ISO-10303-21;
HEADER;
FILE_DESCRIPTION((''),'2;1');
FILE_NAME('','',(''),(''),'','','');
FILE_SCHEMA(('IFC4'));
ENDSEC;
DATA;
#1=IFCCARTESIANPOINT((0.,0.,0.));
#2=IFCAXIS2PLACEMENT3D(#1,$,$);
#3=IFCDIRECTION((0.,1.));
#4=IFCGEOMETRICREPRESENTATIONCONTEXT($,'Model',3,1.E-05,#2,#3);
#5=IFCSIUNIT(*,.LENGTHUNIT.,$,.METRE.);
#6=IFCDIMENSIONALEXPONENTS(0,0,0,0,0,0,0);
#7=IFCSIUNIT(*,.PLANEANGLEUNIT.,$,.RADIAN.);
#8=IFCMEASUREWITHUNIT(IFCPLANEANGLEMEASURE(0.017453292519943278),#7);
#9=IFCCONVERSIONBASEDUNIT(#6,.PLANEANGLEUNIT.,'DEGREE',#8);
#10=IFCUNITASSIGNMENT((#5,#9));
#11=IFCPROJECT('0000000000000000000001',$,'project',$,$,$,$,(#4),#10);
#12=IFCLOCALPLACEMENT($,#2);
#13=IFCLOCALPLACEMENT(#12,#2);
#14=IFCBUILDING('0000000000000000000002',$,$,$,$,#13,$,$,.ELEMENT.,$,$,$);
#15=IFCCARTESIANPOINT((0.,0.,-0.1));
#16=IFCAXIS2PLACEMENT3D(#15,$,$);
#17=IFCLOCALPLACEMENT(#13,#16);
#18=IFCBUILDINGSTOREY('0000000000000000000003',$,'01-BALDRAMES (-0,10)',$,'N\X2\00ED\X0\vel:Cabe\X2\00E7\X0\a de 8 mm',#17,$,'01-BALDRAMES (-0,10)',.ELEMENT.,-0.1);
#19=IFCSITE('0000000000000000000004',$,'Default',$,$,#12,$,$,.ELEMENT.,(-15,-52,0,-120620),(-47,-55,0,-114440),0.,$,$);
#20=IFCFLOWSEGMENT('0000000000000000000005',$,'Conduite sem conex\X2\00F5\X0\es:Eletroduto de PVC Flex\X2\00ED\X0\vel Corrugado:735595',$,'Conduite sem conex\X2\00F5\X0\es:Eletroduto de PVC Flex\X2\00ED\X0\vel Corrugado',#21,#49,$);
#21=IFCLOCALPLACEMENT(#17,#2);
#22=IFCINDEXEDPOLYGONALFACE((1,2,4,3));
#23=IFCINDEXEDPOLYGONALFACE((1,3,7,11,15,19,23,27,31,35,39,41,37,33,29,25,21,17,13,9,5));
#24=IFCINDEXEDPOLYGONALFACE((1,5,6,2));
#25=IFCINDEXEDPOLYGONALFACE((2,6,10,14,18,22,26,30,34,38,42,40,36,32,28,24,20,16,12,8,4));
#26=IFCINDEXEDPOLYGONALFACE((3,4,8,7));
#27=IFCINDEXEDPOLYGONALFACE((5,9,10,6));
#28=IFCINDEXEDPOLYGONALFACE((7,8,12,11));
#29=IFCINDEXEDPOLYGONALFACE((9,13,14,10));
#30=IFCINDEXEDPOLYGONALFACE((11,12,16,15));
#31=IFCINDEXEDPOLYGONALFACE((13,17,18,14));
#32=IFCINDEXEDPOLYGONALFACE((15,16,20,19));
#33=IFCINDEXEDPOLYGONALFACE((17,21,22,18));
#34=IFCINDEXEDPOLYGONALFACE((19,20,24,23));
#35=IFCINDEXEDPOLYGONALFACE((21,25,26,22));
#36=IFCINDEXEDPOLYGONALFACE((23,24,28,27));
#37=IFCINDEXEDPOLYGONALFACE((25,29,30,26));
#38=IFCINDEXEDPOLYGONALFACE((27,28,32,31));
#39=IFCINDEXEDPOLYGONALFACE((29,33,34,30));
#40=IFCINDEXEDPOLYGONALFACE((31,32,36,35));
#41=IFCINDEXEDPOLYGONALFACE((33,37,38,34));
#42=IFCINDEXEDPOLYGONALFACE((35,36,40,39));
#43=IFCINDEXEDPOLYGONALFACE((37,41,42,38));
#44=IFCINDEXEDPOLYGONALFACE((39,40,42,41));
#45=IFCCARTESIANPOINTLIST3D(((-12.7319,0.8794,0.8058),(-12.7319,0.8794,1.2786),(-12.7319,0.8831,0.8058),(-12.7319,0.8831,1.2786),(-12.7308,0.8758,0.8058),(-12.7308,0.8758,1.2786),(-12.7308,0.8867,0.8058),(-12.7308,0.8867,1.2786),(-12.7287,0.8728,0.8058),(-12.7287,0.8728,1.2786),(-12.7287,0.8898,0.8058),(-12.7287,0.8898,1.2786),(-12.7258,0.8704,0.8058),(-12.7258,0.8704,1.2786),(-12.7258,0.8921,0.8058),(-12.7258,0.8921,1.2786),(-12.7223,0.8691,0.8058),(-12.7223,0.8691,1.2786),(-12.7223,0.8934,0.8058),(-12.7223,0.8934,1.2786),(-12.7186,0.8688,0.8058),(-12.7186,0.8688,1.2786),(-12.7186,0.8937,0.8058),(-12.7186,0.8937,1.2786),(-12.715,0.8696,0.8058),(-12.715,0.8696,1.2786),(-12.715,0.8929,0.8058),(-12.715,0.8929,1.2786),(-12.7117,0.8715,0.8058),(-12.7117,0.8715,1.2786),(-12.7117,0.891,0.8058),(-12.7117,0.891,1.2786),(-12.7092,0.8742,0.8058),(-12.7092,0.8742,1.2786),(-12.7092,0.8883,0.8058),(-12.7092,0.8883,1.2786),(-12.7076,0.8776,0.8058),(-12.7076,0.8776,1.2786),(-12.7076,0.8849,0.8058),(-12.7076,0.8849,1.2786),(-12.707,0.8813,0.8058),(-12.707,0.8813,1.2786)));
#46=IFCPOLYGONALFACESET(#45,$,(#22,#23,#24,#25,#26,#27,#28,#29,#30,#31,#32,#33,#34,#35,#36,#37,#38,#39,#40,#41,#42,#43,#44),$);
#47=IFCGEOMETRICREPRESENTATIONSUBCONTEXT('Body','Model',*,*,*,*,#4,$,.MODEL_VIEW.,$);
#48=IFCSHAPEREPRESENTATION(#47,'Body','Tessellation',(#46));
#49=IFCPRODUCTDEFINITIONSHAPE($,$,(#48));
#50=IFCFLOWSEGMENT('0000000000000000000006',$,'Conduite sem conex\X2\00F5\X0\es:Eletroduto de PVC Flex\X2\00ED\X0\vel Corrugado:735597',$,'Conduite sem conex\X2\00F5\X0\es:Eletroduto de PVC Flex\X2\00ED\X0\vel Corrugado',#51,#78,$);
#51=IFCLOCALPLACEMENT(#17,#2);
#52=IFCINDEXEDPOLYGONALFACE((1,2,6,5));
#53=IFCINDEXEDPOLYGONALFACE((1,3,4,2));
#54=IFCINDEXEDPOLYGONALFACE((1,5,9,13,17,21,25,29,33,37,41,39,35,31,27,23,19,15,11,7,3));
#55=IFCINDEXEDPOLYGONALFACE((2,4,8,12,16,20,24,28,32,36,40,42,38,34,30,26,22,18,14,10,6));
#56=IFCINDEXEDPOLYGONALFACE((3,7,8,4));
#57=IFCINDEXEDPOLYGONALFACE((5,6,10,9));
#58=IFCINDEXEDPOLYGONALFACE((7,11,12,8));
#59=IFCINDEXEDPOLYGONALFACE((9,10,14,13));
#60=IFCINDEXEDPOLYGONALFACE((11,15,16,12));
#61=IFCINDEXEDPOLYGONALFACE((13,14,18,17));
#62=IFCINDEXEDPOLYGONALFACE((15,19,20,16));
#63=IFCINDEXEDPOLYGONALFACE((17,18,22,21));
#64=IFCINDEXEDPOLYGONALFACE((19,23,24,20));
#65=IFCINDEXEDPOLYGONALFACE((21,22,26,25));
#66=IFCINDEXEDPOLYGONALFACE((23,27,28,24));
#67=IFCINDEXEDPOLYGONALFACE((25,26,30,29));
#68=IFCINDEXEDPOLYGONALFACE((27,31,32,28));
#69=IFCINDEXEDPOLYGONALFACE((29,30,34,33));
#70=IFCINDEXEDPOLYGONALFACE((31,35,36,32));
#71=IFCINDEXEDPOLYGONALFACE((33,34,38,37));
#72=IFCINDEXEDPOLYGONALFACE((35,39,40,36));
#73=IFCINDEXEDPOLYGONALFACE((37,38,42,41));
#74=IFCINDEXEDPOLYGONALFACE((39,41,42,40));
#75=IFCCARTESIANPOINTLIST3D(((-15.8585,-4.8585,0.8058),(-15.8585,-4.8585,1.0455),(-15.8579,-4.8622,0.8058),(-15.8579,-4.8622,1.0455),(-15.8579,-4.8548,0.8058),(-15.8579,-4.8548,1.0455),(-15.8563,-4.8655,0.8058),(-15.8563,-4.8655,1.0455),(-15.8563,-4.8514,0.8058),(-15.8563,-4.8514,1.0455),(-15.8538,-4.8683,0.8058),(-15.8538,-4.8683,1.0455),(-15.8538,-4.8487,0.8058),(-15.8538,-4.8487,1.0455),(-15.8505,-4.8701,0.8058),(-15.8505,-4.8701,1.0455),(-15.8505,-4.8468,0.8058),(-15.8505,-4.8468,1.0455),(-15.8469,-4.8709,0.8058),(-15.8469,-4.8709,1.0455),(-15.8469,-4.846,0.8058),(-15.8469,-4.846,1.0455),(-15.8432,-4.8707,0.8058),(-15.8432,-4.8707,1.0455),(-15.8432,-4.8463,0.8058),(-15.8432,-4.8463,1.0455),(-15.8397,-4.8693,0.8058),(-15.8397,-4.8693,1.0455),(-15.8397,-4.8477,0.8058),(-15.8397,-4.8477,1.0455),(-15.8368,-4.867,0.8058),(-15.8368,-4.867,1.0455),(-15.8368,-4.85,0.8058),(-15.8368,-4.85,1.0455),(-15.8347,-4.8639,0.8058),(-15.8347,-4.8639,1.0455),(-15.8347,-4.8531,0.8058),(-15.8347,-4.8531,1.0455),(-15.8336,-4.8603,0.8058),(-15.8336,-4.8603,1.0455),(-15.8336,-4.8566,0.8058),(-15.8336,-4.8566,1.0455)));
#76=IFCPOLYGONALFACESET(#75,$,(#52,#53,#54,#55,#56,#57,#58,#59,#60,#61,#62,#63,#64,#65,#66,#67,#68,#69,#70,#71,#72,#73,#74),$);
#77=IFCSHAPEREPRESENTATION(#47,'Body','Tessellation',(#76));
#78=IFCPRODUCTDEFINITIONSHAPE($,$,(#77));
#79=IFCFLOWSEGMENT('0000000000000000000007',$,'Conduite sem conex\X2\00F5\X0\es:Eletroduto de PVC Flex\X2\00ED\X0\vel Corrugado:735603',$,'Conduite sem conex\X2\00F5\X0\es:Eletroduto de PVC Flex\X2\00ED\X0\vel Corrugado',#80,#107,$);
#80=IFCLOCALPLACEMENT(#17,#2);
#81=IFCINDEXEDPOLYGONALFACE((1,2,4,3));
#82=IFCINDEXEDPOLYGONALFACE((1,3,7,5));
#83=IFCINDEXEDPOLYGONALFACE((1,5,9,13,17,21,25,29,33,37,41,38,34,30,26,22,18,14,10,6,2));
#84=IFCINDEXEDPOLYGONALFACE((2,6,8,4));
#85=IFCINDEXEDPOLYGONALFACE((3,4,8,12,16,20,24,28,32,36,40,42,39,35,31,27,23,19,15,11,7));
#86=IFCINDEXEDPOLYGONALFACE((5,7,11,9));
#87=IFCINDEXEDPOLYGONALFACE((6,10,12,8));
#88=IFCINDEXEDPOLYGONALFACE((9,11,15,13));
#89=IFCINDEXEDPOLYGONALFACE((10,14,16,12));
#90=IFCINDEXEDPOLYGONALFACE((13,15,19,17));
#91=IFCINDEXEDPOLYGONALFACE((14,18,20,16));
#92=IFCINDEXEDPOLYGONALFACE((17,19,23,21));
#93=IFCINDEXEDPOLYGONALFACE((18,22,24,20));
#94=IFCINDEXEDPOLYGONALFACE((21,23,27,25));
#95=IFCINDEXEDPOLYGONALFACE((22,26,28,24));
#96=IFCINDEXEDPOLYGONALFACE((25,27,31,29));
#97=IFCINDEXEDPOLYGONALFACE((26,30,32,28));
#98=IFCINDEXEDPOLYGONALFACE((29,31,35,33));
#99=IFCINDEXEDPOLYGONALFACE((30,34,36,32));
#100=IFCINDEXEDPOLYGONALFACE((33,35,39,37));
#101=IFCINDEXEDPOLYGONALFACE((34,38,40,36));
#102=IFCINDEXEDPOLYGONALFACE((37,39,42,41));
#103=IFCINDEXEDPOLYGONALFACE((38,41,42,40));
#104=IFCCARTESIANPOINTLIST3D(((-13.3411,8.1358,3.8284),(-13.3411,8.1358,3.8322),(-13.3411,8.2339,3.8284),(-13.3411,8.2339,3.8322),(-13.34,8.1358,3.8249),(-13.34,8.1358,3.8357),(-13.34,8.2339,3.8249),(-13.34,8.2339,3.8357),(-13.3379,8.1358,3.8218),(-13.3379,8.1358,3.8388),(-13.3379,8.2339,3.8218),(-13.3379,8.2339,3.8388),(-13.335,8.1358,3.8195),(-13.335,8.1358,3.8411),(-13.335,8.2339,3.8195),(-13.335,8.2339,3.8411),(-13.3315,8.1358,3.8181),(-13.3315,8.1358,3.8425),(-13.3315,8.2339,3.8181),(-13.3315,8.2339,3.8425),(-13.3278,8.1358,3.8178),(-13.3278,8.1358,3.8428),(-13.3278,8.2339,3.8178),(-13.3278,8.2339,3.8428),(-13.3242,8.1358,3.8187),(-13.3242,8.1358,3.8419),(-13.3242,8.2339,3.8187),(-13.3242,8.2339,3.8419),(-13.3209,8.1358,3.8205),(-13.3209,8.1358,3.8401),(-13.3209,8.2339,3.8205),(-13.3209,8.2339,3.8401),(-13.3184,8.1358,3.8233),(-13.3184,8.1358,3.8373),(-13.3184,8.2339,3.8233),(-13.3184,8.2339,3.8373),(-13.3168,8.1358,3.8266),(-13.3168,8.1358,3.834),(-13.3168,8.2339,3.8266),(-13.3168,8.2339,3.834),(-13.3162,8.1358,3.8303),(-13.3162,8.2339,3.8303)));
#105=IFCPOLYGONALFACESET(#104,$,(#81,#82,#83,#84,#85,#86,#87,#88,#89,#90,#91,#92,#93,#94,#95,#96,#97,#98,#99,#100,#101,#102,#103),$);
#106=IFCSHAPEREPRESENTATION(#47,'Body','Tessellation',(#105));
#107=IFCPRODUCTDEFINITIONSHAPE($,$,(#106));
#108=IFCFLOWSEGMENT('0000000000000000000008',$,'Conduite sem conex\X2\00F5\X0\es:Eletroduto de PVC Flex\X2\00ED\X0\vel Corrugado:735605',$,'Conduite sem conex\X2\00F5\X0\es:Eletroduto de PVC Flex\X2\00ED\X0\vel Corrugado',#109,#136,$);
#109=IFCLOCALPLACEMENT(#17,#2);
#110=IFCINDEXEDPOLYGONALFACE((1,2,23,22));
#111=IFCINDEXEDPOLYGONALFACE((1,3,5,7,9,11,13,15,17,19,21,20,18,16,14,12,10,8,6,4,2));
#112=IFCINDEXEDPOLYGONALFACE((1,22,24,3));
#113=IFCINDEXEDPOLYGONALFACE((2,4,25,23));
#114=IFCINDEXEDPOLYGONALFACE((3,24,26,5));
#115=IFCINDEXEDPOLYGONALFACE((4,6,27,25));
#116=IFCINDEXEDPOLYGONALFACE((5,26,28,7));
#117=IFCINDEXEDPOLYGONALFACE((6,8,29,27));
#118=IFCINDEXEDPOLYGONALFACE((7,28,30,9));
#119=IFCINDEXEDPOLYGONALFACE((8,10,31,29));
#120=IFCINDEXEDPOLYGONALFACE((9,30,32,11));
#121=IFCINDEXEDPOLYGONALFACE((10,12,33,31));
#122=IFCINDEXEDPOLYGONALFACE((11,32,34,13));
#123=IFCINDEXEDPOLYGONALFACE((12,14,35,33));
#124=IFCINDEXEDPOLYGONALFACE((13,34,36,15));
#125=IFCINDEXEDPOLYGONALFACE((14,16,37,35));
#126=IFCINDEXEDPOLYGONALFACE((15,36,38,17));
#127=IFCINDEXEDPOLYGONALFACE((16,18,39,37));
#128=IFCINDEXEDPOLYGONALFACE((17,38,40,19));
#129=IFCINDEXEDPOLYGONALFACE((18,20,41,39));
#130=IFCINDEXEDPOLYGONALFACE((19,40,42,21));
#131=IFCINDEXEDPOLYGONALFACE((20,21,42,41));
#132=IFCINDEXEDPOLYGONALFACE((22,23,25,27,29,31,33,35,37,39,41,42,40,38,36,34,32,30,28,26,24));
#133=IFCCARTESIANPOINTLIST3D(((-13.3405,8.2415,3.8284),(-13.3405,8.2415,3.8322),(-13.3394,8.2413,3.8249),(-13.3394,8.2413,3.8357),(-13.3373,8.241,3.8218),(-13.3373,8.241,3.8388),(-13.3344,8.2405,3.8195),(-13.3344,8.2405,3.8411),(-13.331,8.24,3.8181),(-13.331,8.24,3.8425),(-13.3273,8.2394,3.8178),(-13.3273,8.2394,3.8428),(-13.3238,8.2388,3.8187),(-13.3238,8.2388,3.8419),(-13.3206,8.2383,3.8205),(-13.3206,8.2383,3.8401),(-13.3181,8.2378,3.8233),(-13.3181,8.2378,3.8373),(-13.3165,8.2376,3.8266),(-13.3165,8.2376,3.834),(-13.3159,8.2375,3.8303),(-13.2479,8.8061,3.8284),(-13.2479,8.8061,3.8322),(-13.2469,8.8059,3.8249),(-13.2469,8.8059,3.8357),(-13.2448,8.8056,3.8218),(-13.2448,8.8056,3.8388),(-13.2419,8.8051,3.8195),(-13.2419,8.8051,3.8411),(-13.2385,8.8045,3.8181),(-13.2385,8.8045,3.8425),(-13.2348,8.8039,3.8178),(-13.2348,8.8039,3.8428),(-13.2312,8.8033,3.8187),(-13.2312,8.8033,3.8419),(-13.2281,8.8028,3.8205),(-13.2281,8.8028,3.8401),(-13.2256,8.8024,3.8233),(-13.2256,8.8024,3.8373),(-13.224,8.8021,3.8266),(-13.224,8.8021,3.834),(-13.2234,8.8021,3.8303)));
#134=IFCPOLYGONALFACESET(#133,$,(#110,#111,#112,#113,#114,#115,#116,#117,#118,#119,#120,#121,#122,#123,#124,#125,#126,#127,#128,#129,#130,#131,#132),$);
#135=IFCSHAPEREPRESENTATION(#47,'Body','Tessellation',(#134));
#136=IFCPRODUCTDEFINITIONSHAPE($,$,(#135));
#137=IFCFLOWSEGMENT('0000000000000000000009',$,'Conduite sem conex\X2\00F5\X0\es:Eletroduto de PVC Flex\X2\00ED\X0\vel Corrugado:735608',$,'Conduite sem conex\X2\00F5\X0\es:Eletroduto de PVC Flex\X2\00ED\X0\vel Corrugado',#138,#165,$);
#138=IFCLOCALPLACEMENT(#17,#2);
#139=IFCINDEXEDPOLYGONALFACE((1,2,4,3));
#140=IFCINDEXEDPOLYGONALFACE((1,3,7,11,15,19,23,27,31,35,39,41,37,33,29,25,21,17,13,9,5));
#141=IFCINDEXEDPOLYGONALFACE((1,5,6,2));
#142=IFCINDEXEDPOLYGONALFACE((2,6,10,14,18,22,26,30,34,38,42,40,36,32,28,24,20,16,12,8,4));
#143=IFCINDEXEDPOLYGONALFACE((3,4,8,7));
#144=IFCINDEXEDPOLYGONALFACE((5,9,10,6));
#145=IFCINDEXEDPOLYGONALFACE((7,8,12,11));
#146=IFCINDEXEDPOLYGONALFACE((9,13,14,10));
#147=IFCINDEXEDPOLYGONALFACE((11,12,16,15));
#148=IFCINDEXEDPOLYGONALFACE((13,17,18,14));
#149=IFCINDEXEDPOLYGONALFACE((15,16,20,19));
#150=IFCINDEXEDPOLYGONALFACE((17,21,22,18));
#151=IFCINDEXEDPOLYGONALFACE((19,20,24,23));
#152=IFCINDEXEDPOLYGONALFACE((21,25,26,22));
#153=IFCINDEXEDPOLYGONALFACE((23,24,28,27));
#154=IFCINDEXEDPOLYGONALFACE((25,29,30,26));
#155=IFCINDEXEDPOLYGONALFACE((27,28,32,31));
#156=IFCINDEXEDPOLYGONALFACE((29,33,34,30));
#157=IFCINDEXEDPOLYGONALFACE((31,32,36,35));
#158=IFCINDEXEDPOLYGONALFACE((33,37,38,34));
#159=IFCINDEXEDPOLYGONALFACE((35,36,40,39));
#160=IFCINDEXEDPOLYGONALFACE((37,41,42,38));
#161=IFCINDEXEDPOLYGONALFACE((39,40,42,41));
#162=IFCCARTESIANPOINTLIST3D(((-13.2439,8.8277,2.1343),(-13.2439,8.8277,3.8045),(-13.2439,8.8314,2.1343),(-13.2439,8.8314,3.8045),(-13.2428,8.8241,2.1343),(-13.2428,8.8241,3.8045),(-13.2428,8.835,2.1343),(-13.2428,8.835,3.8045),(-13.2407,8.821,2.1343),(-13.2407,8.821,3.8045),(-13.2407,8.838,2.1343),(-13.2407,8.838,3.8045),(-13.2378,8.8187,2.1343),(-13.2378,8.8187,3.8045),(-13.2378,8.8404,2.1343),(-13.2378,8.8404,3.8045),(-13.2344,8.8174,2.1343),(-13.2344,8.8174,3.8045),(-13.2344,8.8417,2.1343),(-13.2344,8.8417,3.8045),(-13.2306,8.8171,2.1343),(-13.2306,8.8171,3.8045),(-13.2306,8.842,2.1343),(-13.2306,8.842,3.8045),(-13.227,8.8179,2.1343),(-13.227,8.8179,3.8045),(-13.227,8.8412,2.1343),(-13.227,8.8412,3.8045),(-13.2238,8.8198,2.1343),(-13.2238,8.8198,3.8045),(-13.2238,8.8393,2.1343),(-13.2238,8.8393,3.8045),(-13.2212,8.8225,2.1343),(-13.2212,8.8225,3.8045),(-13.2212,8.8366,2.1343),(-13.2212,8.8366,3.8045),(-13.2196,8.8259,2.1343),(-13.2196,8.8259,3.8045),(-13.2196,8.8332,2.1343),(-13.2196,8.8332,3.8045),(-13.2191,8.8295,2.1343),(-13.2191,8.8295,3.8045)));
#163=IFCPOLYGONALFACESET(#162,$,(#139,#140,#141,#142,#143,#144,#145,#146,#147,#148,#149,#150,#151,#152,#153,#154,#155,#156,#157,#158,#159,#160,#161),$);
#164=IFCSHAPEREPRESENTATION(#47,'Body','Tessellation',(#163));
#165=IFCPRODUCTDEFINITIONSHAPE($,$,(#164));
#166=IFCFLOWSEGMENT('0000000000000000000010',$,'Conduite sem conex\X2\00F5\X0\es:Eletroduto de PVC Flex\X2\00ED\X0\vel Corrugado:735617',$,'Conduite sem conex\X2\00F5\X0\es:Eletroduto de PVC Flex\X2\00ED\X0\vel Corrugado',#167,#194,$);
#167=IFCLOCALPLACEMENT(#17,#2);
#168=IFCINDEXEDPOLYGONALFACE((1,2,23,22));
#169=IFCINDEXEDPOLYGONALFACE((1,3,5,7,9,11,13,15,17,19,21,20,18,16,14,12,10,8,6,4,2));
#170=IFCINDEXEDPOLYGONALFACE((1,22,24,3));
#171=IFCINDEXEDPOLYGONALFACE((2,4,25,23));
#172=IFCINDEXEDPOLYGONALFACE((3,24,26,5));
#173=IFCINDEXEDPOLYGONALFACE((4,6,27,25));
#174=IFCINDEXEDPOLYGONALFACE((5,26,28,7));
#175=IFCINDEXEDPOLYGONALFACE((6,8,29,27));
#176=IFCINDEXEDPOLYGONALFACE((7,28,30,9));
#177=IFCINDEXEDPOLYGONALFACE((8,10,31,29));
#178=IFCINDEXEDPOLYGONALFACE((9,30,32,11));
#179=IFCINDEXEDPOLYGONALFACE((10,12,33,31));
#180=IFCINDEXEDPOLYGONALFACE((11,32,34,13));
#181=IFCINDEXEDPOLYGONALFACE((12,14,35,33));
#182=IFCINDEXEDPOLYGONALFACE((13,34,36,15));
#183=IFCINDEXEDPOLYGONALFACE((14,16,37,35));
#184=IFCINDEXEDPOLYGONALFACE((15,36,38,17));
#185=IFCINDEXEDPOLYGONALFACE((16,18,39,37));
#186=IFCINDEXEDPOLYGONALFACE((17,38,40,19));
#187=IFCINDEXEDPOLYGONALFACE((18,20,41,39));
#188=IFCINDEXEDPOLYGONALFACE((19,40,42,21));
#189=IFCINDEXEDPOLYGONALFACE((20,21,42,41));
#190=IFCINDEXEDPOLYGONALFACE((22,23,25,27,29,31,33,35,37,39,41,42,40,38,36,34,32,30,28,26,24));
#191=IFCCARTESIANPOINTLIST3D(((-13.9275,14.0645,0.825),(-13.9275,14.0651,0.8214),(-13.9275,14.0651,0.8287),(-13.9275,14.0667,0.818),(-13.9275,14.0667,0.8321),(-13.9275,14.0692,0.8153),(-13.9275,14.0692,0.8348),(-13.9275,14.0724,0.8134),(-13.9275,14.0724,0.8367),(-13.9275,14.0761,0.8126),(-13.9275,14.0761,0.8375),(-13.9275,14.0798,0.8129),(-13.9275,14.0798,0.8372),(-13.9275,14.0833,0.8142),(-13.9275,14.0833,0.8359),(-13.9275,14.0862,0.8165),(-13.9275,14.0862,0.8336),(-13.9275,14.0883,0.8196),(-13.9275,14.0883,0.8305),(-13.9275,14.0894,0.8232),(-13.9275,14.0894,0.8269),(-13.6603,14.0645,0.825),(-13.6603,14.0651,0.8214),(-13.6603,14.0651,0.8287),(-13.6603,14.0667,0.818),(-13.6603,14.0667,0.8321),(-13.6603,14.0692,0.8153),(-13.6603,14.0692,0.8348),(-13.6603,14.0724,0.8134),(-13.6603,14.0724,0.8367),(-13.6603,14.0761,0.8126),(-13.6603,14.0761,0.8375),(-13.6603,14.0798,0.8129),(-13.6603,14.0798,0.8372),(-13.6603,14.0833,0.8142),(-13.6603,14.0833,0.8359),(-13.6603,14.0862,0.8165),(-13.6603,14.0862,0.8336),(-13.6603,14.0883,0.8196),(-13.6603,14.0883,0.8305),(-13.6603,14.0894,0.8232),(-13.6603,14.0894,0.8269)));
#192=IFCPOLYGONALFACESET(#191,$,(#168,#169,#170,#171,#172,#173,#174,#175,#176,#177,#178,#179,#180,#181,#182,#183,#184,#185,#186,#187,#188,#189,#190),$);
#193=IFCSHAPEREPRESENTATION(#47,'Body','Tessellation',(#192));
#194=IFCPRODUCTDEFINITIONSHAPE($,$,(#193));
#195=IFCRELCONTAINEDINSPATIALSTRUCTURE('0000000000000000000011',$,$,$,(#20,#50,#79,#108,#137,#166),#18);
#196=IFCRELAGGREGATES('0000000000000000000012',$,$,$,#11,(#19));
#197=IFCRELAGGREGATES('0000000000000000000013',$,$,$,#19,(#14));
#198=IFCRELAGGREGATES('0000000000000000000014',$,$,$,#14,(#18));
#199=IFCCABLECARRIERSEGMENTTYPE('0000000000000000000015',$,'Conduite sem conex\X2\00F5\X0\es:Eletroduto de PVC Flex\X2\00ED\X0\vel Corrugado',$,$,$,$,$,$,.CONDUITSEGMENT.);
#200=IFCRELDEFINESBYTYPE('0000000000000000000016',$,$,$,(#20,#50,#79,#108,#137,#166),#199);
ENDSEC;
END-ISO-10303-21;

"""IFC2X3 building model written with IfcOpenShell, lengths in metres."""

from ifc_helpers import new_model, entity, si_unit, converted_unit, direction, frame, frame_2d, origin, origin_2d_with_axis, place, context, subcontext, project, spatial, circle, extrude, type_object, element, save


model = new_model("IFC2X3")

# Units and contexts
model_context = context("Model", 3, precision=1e-05, world=origin(), true_north=direction((0.0, 1.0)))
body_context = subcontext(model_context, "Body", "Model", "MODEL_VIEW")
ifc_project = project(units=[si_unit("LENGTHUNIT", "METRE"), converted_unit("PLANEANGLEUNIT", "DEGREE", entity("IfcPlaneAngleMeasure", 0.017453292519943278), si_unit("PLANEANGLEUNIT", "RADIAN"), dimensions=[0, 0, 0, 0, 0, 0, 0])], contexts=[model_context])

# Site, building, storey
site_placement = place(None, origin())
site = spatial("IfcSite", under=ifc_project, at=site_placement, Name="Default", CompositionType="ELEMENT", RefLatitude=(-15, -52, 0, -120620), RefLongitude=(-47, -55, 0, -114440), RefElevation=0.0)
building_placement = place(site_placement, origin())
building = spatial("IfcBuilding", under=site, at=building_placement, CompositionType="ELEMENT")
storey_placement = place(building_placement, frame((0.0, 0.0, -0.1)))
storey = spatial("IfcBuildingStorey", under=building, at=storey_placement, Name="01-BALDRAMES (-0,10)", ObjectType="Nível:Cabeça de 8 mm", LongName="01-BALDRAMES (-0,10)", CompositionType="ELEMENT", Elevation=-0.1)

# Flow segments
cable_carrier_segment_type = type_object("IfcCableCarrierSegmentType", Name="Conduite sem conexões:Eletroduto de PVC Flexível Corrugado", PredefinedType="CONDUITSEGMENT")
flow_segment_1_placement = place(storey_placement, origin())
element("IfcFlowSegment", 1, at=flow_segment_1_placement, inside=storey, type_object=cable_carrier_segment_type, Name="Conduite sem conexões:Eletroduto de PVC Flexível Corrugado:735595", ObjectType="Conduite sem conexões:Eletroduto de PVC Flexível Corrugado", context=body_context, shape_type="SweptSolid", body=[
    extrude(circle(Radius=0.0125, at=frame_2d((0.0, 0.0), x_axis=(1.0, 0.0))), frame((-12.7195, 0.8813, 0.8058)), (0.0, 0.0, 1.0), 0.4728),
])
flow_segment_2_placement = place(storey_placement, origin())
element("IfcFlowSegment", 2, at=flow_segment_2_placement, inside=storey, type_object=cable_carrier_segment_type, Name="Conduite sem conexões:Eletroduto de PVC Flexível Corrugado:735597", ObjectType="Conduite sem conexões:Eletroduto de PVC Flexível Corrugado", context=body_context, shape_type="SweptSolid", body=[
    extrude(circle(Radius=0.0125, at=frame_2d((0.0, 0.0), x_axis=(1.0, 0.0))), frame((-15.846, -4.8585, 0.8058), z_axis=(0.0, 0.0, 1.0), x_axis=(-1.0, 0.0, 0.0)), (0.0, 0.0, 1.0), 0.2397),
])
flow_segment_3_placement = place(storey_placement, origin())
element("IfcFlowSegment", 3, at=flow_segment_3_placement, inside=storey, type_object=cable_carrier_segment_type, Name="Conduite sem conexões:Eletroduto de PVC Flexível Corrugado:735603", ObjectType="Conduite sem conexões:Eletroduto de PVC Flexível Corrugado", context=body_context, shape_type="SweptSolid", body=[
    extrude(circle(Radius=0.0125, at=origin_2d_with_axis()), frame((-13.3287, 8.1358, 3.8303), z_axis=(0.0, 1.0, 0.0), x_axis=(1.0, 0.0, 0.0)), (0.0, 0.0, 1.0), 0.0981),
])
flow_segment_4_placement = place(storey_placement, origin())
element("IfcFlowSegment", 4, at=flow_segment_4_placement, inside=storey, type_object=cable_carrier_segment_type, Name="Conduite sem conexões:Eletroduto de PVC Flexível Corrugado:735605", ObjectType="Conduite sem conexões:Eletroduto de PVC Flexível Corrugado", context=body_context, shape_type="SweptSolid", body=[
    extrude(circle(Radius=0.0125, at=frame_2d((0.0, 0.0), x_axis=(1.0, 0.0))), frame((-13.3283, 8.2395, 3.8303), z_axis=(0.161723, 0.986836, 0.0), x_axis=(0.986836, -0.161723, 0.0)), (0.0, 0.0, 1.0), 0.5721),
])
flow_segment_5_placement = place(storey_placement, origin())
element("IfcFlowSegment", 5, at=flow_segment_5_placement, inside=storey, type_object=cable_carrier_segment_type, Name="Conduite sem conexões:Eletroduto de PVC Flexível Corrugado:735608", ObjectType="Conduite sem conexões:Eletroduto de PVC Flexível Corrugado", context=body_context, shape_type="SweptSolid", body=[
    extrude(circle(Radius=0.0125, at=frame_2d((0.0, 0.0), x_axis=(1.0, 0.0))), frame((-13.2316, 8.8295, 2.1343)), (0.0, 0.0, 1.0), 1.6702),
])
flow_segment_6_placement = place(storey_placement, origin())
element("IfcFlowSegment", 6, at=flow_segment_6_placement, inside=storey, type_object=cable_carrier_segment_type, Name="Conduite sem conexões:Eletroduto de PVC Flexível Corrugado:735617", ObjectType="Conduite sem conexões:Eletroduto de PVC Flexível Corrugado", context=body_context, shape_type="SweptSolid", body=[
    extrude(circle(Radius=0.0125, at=origin_2d_with_axis()), frame((-13.9275, 14.077, 0.825), z_axis=(1.0, 0.0, 0.0), x_axis=(0.0, -1.0, 0.0)), (0.0, 0.0, 1.0), 0.2672),
])

save(model, "model.ifc")
